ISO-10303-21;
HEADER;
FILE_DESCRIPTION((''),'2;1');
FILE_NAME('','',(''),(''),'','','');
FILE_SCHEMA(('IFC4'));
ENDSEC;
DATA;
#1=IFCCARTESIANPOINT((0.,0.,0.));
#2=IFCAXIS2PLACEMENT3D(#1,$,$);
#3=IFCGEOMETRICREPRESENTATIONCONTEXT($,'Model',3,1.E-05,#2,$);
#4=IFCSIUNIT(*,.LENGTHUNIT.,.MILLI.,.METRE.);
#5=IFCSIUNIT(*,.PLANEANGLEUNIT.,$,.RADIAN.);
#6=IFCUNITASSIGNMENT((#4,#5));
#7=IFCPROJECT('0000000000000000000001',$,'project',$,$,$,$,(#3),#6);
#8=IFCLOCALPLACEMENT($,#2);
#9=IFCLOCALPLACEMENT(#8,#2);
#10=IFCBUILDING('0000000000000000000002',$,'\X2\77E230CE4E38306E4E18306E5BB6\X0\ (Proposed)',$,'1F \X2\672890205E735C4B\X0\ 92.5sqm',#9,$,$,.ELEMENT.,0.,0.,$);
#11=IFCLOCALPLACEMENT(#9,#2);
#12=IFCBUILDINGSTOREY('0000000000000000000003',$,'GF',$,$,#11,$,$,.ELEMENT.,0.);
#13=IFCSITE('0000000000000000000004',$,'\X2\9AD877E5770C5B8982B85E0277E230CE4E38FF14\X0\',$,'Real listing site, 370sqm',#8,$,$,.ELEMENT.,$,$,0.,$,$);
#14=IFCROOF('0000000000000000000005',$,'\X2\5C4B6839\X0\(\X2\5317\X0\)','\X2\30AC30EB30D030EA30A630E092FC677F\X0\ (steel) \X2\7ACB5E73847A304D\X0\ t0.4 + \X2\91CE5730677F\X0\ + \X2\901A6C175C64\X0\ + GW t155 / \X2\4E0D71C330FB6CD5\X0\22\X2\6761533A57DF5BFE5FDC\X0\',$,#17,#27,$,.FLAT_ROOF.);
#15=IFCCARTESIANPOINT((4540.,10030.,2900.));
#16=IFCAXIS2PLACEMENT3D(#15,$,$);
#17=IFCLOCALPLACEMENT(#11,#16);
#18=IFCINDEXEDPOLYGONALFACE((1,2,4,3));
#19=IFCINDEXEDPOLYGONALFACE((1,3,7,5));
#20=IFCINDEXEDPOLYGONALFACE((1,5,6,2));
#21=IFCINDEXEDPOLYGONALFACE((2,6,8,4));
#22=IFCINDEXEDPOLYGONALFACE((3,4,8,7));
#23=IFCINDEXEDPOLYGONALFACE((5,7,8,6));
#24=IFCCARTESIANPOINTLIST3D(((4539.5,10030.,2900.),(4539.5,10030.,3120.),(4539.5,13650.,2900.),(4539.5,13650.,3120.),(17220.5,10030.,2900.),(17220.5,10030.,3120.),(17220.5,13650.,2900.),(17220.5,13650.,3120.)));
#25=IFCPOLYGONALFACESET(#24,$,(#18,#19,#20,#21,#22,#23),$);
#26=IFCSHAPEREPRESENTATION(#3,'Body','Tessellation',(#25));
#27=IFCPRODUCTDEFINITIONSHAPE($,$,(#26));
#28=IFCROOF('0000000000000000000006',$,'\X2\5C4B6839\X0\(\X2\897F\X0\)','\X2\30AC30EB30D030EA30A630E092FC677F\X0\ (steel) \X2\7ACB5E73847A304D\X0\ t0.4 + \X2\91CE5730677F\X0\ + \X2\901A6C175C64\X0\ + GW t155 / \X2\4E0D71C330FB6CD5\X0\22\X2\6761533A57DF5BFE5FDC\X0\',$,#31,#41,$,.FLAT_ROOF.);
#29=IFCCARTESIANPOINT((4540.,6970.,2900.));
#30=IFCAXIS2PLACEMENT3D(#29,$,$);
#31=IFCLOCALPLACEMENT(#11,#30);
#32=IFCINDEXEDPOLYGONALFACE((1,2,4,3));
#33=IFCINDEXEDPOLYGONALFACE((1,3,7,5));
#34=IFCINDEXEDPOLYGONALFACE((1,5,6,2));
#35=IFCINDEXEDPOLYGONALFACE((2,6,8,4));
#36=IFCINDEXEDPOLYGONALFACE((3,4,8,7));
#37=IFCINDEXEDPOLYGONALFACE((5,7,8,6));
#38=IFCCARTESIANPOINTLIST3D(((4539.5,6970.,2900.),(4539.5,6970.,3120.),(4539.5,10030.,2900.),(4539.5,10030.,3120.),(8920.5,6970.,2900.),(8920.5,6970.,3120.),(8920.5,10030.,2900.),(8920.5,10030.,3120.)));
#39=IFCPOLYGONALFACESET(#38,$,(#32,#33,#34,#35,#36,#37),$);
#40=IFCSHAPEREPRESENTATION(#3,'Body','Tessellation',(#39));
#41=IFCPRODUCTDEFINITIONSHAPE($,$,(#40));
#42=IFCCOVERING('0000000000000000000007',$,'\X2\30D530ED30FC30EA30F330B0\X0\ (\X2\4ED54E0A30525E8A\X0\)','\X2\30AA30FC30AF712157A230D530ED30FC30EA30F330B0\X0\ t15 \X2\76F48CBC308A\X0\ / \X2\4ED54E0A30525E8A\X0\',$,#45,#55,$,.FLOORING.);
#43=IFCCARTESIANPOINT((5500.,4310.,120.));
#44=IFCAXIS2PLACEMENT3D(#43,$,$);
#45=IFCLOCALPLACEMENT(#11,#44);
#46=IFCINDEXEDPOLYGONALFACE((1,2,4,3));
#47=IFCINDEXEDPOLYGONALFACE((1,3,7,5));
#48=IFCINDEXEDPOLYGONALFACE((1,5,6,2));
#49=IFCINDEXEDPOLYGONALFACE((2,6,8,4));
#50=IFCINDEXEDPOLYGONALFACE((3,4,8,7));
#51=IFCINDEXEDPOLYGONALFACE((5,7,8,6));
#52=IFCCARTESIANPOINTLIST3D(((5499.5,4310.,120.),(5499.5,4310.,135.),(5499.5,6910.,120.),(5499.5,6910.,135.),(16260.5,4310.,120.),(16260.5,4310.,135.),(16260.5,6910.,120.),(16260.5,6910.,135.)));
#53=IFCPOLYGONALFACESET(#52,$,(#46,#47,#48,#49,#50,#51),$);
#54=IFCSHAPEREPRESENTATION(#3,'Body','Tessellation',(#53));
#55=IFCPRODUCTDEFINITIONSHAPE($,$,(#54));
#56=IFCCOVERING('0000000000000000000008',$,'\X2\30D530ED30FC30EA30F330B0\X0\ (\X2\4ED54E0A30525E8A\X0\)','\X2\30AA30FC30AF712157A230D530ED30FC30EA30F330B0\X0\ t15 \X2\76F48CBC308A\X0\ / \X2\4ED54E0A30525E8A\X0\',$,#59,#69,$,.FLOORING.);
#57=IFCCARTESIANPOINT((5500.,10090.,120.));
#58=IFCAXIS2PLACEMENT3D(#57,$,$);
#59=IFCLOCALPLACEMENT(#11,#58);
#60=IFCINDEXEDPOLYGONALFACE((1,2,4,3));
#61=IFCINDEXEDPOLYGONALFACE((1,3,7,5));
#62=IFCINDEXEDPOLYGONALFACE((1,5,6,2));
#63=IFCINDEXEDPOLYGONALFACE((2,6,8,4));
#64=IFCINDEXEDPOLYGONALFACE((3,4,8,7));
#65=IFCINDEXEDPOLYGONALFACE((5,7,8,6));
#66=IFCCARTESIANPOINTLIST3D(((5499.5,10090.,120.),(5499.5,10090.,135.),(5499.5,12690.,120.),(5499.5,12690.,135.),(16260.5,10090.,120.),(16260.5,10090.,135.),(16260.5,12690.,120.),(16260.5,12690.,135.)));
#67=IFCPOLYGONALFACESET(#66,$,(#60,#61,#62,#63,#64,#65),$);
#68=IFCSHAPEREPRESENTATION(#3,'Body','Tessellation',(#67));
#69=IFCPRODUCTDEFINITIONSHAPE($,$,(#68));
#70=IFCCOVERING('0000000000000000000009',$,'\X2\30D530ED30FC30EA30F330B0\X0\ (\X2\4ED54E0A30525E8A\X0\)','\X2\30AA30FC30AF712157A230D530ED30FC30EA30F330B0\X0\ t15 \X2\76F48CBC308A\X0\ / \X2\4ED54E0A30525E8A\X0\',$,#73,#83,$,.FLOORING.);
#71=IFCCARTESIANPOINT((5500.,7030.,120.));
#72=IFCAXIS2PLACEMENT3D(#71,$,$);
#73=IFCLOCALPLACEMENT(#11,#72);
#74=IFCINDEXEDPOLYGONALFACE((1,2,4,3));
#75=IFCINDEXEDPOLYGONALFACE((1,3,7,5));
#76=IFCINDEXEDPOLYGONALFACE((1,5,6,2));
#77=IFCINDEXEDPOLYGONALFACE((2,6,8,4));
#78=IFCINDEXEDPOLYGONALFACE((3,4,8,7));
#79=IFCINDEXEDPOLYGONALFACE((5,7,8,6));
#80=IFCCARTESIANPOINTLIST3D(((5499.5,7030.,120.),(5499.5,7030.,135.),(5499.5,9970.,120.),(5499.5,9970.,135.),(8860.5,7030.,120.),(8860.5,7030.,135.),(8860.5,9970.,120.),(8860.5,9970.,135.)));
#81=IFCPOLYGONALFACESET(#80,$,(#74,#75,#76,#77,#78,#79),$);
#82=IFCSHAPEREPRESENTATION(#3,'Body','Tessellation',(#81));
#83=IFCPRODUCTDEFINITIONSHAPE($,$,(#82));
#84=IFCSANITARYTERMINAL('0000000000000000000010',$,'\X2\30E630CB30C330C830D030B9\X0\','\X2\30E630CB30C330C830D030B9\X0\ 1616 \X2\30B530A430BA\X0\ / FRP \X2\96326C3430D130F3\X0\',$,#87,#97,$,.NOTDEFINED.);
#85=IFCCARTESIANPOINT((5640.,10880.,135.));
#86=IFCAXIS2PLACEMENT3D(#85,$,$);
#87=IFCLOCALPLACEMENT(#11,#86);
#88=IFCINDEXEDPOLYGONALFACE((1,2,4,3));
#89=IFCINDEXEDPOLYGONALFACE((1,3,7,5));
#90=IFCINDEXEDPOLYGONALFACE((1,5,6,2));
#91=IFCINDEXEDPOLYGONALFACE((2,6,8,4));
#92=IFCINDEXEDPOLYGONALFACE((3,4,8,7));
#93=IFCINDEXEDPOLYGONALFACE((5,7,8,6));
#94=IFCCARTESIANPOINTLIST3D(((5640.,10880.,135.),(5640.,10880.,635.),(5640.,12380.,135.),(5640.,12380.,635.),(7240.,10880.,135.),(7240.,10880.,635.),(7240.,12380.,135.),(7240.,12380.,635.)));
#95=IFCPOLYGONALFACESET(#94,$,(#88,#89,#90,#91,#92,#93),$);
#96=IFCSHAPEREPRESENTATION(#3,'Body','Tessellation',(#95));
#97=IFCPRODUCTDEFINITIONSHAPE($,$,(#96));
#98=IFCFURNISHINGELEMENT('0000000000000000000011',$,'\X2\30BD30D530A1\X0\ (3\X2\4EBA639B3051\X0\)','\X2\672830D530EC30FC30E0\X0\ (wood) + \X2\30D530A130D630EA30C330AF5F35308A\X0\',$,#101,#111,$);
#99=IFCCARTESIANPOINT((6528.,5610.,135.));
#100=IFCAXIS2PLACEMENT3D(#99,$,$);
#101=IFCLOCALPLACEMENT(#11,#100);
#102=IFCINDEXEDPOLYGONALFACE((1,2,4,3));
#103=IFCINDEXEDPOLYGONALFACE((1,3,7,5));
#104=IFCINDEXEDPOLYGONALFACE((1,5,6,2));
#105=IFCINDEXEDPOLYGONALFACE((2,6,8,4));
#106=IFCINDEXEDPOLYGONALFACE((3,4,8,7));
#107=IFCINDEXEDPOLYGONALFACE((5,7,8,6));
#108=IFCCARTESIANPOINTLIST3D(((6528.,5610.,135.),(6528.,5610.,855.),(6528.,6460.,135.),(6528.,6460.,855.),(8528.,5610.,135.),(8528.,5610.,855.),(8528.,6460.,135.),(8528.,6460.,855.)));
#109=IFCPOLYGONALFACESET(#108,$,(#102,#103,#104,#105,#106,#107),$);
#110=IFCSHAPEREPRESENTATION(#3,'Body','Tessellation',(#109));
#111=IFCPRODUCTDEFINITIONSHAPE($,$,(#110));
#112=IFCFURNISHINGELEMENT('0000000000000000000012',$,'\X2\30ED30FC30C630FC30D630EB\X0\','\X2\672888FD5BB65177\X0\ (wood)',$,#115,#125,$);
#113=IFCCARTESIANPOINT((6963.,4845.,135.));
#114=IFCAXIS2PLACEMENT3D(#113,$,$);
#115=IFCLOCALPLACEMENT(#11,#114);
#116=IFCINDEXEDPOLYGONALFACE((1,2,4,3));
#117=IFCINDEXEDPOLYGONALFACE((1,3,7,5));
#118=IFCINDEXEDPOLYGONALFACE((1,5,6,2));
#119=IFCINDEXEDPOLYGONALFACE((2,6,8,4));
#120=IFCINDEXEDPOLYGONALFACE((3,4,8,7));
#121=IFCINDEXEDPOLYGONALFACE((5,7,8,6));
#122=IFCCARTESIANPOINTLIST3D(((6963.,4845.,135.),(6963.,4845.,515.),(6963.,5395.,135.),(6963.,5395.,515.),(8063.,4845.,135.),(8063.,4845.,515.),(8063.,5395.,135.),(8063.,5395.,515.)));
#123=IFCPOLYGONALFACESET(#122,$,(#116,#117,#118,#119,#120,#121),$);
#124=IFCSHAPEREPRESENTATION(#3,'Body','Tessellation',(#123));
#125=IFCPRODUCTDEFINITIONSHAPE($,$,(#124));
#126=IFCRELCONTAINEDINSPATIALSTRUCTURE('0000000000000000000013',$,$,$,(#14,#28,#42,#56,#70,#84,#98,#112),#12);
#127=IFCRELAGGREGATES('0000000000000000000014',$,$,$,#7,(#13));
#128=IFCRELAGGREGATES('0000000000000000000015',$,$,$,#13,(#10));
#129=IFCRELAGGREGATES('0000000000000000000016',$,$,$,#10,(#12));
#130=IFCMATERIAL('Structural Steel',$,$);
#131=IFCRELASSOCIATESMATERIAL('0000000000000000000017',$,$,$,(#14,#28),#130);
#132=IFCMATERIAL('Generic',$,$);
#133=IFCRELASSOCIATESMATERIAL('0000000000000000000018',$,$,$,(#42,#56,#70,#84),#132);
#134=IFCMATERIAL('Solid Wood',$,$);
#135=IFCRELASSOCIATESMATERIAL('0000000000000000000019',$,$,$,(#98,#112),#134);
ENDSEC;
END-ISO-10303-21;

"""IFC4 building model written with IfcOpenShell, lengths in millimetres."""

from ifc_helpers import new_model, si_unit, frame, frame_2d, origin, place, context, project, spatial, rectangle, extrude, material, element, save


model = new_model("IFC4")

# Units and contexts
model_context = context("Model", 3, precision=1e-05, world=origin())
ifc_project = project(units=[si_unit("LENGTHUNIT", "METRE", prefix="MILLI"), si_unit("PLANEANGLEUNIT", "RADIAN")], contexts=[model_context])

# Site, building, storey
site_placement = place(None, origin())
site = spatial("IfcSite", under=ifc_project, at=site_placement, Name="高知県安芸市矢ノ丸４", ObjectType="Real listing site, 370sqm", CompositionType="ELEMENT", RefElevation=0.0)
building_placement = place(site_placement, origin())
building = spatial("IfcBuilding", under=site, at=building_placement, Name="矢ノ丸の丘の家 (Proposed)", ObjectType="1F 木造平屋 92.5sqm", CompositionType="ELEMENT", ElevationOfRefHeight=0.0, ElevationOfTerrain=0.0)
storey_placement = place(building_placement, origin())
storey = spatial("IfcBuildingStorey", under=building, at=storey_placement, Name="GF", CompositionType="ELEMENT", Elevation=0.0)

# Shared definitions
ifc_material_1 = material(Name="Solid Wood")

# Roofs
ifc_material_2 = material(Name="Structural Steel")
roof_1_placement = place(storey_placement, frame((4540.0, 10030.0, 2900.0)))
element("IfcRoof", 1, at=roof_1_placement, inside=storey, material=ifc_material_2, Name="屋根(北)", Description="ガルバリウム鋼板 (steel) 立平葺き t0.4 + 野地板 + 通気層 + GW t155 / 不燃・法22条区域対応", PredefinedType="FLAT_ROOF", context=model_context, shape_type="SweptSolid", body=[
    extrude(rectangle(XDim=12681.0, YDim=3620.0, at=frame_2d((6340.0, 1810.0))), frame((4540.0, 10030.0, 2900.0)), (0.0, 0.0, 1.0), 220.0),
])
roof_2_placement = place(storey_placement, frame((4540.0, 6970.0, 2900.0)))
element("IfcRoof", 2, at=roof_2_placement, inside=storey, material=ifc_material_2, Name="屋根(西)", Description="ガルバリウム鋼板 (steel) 立平葺き t0.4 + 野地板 + 通気層 + GW t155 / 不燃・法22条区域対応", PredefinedType="FLAT_ROOF", context=model_context, shape_type="SweptSolid", body=[
    extrude(rectangle(XDim=4381.0, YDim=3060.0, at=frame_2d((2190.0, 1530.0))), frame((4540.0, 6970.0, 2900.0)), (0.0, 0.0, 1.0), 220.0),
])

# Coverings
ifc_material_3 = material(Name="Generic")
covering_1_placement = place(storey_placement, frame((5500.0, 4310.0, 120.0)))
element("IfcCovering", 3, at=covering_1_placement, inside=storey, material=ifc_material_3, Name="フローリング (仕上げ床)", Description="オーク無垢フローリング t15 直貼り / 仕上げ床", PredefinedType="FLOORING", context=model_context, shape_type="SweptSolid", body=[
    extrude(rectangle(XDim=10761.0, YDim=2600.0, at=frame_2d((5380.0, 1300.0))), frame((5500.0, 4310.0, 120.0)), (0.0, 0.0, 1.0), 15.0),
])
covering_2_placement = place(storey_placement, frame((5500.0, 10090.0, 120.0)))
element("IfcCovering", 4, at=covering_2_placement, inside=storey, material=ifc_material_3, Name="フローリング (仕上げ床)", Description="オーク無垢フローリング t15 直貼り / 仕上げ床", PredefinedType="FLOORING", context=model_context, shape_type="SweptSolid", body=[
    extrude(rectangle(XDim=10761.0, YDim=2600.0, at=frame_2d((5380.0, 1300.0))), frame((5500.0, 10090.0, 120.0)), (0.0, 0.0, 1.0), 15.0),
])
covering_3_placement = place(storey_placement, frame((5500.0, 7030.0, 120.0)))
element("IfcCovering", 5, at=covering_3_placement, inside=storey, material=ifc_material_3, Name="フローリング (仕上げ床)", Description="オーク無垢フローリング t15 直貼り / 仕上げ床", PredefinedType="FLOORING", context=model_context, shape_type="SweptSolid", body=[
    extrude(rectangle(XDim=3361.0, YDim=2940.0, at=frame_2d((1680.0, 1470.0))), frame((5500.0, 7030.0, 120.0)), (0.0, 0.0, 1.0), 15.0),
])

# Sanitary terminal
sanitary_terminal_placement = place(storey_placement, frame((5640.0, 10880.0, 135.0)))
element("IfcSanitaryTerminal", 6, at=sanitary_terminal_placement, inside=storey, material=ifc_material_3, Name="ユニットバス", Description="ユニットバス 1616 サイズ / FRP 防水パン", PredefinedType="NOTDEFINED", context=model_context, shape_type="SweptSolid", body=[
    extrude(rectangle(XDim=1600.0, YDim=1500.0, at=frame_2d((800.0, 750.0))), frame((5640.0, 10880.0, 135.0)), (0.0, 0.0, 1.0), 500.0),
])

# Furnishing elements
furnishing_1_placement = place(storey_placement, frame((6528.0, 5610.0, 135.0)))
element("IfcFurnishingElement", 7, at=furnishing_1_placement, inside=storey, material=ifc_material_1, Name="ソファ (3人掛け)", Description="木フレーム (wood) + ファブリック張り", context=model_context, shape_type="SweptSolid", body=[
    extrude(rectangle(XDim=2000.0, YDim=850.0, at=frame_2d((1000.0, 425.0))), frame((6528.0, 5610.0, 135.0)), (0.0, 0.0, 1.0), 720.0),
])
furnishing_2_placement = place(storey_placement, frame((6963.0, 4845.0, 135.0)))
element("IfcFurnishingElement", 8, at=furnishing_2_placement, inside=storey, material=ifc_material_1, Name="ローテーブル", Description="木製家具 (wood)", context=model_context, shape_type="SweptSolid", body=[
    extrude(rectangle(XDim=1100.0, YDim=550.0, at=frame_2d((550.0, 275.0))), frame((6963.0, 4845.0, 135.0)), (0.0, 0.0, 1.0), 380.0),
])

save(model, "model.ifc")
